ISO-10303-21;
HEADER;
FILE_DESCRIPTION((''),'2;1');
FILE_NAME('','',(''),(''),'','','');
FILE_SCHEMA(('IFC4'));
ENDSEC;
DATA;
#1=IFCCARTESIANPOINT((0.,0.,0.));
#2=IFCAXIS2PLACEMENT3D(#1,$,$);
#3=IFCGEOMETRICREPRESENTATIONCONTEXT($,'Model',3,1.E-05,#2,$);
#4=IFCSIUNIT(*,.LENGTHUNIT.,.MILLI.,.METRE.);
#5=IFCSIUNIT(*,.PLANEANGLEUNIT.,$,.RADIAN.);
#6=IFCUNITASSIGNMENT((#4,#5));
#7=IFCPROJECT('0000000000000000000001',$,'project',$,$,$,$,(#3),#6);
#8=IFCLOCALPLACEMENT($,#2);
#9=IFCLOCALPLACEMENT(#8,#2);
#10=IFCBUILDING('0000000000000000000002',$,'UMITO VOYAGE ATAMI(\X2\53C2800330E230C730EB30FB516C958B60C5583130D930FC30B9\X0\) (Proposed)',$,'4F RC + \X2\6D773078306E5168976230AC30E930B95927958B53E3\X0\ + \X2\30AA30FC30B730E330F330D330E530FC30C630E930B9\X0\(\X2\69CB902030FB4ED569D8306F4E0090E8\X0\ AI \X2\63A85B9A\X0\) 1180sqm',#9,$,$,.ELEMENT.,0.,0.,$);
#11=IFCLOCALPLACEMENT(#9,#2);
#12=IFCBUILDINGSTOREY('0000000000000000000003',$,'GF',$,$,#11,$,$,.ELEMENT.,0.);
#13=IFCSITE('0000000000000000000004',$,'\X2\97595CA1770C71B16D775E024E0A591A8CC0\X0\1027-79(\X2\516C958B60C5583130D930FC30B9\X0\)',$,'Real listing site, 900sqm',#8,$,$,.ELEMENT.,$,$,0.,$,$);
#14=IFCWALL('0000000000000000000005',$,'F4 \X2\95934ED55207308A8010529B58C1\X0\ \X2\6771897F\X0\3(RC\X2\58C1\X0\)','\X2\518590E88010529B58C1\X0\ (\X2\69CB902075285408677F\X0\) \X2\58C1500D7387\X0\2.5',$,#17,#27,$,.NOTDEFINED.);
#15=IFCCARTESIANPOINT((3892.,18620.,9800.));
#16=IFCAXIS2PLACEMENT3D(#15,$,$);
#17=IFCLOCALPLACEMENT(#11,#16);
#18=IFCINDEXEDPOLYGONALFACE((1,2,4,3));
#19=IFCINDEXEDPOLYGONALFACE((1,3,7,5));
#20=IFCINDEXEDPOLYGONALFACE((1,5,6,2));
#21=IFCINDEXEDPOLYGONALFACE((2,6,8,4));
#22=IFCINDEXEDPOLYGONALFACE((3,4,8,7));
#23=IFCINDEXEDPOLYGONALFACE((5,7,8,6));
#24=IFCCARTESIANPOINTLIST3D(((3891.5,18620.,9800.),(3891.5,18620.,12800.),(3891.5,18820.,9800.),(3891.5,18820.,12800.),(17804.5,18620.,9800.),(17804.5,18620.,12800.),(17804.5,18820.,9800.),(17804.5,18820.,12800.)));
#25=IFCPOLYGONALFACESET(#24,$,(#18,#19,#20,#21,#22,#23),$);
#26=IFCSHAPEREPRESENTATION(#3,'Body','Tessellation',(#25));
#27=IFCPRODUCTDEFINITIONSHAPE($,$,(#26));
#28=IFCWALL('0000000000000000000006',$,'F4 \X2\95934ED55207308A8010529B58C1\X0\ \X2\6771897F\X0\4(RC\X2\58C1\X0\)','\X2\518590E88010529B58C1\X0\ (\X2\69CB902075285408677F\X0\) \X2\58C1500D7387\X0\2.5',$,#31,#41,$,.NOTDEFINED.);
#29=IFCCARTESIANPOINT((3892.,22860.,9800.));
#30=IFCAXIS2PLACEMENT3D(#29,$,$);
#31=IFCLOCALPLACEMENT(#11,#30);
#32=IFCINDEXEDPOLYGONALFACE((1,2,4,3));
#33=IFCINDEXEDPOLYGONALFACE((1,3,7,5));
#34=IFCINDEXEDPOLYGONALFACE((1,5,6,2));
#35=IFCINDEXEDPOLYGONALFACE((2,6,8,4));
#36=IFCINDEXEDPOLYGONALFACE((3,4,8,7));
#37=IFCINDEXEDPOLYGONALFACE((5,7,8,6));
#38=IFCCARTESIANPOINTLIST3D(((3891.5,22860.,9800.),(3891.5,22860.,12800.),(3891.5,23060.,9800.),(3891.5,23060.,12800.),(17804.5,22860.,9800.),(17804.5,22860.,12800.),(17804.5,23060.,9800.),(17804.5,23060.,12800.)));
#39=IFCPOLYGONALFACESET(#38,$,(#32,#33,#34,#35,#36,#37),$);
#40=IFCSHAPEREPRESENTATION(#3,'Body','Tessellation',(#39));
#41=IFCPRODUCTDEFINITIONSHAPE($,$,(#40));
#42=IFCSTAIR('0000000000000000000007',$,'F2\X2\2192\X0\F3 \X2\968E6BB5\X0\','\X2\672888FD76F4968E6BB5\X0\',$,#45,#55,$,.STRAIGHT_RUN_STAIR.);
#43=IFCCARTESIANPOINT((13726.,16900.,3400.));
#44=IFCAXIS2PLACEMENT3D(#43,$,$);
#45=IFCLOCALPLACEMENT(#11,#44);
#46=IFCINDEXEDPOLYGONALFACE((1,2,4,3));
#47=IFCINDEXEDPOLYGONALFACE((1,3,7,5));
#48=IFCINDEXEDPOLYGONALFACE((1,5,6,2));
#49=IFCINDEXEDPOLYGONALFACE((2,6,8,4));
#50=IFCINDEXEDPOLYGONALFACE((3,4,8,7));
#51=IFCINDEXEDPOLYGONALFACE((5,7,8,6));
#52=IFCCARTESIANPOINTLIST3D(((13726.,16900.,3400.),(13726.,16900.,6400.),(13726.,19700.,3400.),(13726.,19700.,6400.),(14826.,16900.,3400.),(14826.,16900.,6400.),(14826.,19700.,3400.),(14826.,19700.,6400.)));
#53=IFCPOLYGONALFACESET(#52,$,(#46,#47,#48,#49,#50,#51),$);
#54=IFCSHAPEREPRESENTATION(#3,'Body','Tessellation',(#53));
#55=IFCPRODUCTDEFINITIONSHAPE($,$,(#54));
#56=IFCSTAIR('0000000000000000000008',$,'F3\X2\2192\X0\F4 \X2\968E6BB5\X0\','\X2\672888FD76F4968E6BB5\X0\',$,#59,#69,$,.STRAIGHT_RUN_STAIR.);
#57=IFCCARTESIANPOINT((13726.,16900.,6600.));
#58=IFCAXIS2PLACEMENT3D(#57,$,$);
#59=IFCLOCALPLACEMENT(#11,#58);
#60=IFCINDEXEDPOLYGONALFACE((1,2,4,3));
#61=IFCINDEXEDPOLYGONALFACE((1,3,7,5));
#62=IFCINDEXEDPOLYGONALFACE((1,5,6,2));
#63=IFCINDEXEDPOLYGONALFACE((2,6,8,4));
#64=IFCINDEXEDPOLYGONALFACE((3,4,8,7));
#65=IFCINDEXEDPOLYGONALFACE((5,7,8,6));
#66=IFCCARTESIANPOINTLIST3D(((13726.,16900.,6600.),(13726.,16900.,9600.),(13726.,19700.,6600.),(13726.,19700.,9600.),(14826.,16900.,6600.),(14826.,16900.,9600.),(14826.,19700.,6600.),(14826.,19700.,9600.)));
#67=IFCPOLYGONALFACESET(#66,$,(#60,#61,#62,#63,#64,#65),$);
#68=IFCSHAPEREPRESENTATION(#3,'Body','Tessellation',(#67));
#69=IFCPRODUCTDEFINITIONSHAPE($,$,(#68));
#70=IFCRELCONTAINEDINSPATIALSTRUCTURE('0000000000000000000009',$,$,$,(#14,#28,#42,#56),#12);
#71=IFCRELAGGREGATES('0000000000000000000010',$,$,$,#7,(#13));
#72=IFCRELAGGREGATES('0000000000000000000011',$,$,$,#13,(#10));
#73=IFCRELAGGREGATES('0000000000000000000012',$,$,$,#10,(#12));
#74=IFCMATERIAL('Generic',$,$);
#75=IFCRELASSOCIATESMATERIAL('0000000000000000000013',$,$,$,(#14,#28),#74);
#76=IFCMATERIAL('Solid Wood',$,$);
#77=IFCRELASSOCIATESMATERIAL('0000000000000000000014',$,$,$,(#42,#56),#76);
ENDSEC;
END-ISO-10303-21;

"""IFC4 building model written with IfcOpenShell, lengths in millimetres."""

from ifc_helpers import new_model, si_unit, frame, frame_2d, origin, place, context, project, spatial, rectangle, extrude, material, element, save


model = new_model("IFC4")

# Units and contexts
model_context = context("Model", 3, precision=1e-05, world=origin())
ifc_project = project(units=[si_unit("LENGTHUNIT", "METRE", prefix="MILLI"), si_unit("PLANEANGLEUNIT", "RADIAN")], contexts=[model_context])

# Site, building, storey
site_placement = place(None, origin())
site = spatial("IfcSite", under=ifc_project, at=site_placement, Name="静岡県熱海市上多賀1027-79(公開情報ベース)", ObjectType="Real listing site, 900sqm", CompositionType="ELEMENT", RefElevation=0.0)
building_placement = place(site_placement, origin())
building = spatial("IfcBuilding", under=site, at=building_placement, Name="UMITO VOYAGE ATAMI(参考モデル・公開情報ベース) (Proposed)", ObjectType="4F RC + 海への全面ガラス大開口 + オーシャンビューテラス(構造・仕様は一部 AI 推定) 1180sqm", CompositionType="ELEMENT", ElevationOfRefHeight=0.0, ElevationOfTerrain=0.0)
storey_placement = place(building_placement, origin())
storey = spatial("IfcBuildingStorey", under=building, at=storey_placement, Name="GF", CompositionType="ELEMENT", Elevation=0.0)

# Shared definitions
ifc_material_1 = material(Name="Generic")

# Walls
wall_1_placement = place(storey_placement, frame((3892.0, 18620.0, 9800.0)))
element("IfcWall", 1, at=wall_1_placement, inside=storey, material=ifc_material_1, Name="F4 間仕切り耐力壁 東西3(RC壁)", Description="内部耐力壁 (構造用合板) 壁倍率2.5", PredefinedType="NOTDEFINED", context=model_context, shape_type="SweptSolid", body=[
    extrude(rectangle(XDim=13913.0, YDim=200.0, at=frame_2d((6956.0, 100.0))), frame((3892.0, 18620.0, 9800.0)), (0.0, 0.0, 1.0), 3000.0),
])
wall_2_placement = place(storey_placement, frame((3892.0, 22860.0, 9800.0)))
element("IfcWall", 2, at=wall_2_placement, inside=storey, material=ifc_material_1, Name="F4 間仕切り耐力壁 東西4(RC壁)", Description="内部耐力壁 (構造用合板) 壁倍率2.5", PredefinedType="NOTDEFINED", context=model_context, shape_type="SweptSolid", body=[
    extrude(rectangle(XDim=13913.0, YDim=200.0, at=frame_2d((6956.0, 100.0))), frame((3892.0, 22860.0, 9800.0)), (0.0, 0.0, 1.0), 3000.0),
])

# Stairs
ifc_material_2 = material(Name="Solid Wood")
stair_1_placement = place(storey_placement, frame((13726.0, 16900.0, 3400.0)))
element("IfcStair", 3, at=stair_1_placement, inside=storey, material=ifc_material_2, Name="F2→F3 階段", Description="木製直階段", PredefinedType="STRAIGHT_RUN_STAIR", context=model_context, shape_type="SweptSolid", body=[
    extrude(rectangle(XDim=1100.0, YDim=2800.0, at=frame_2d((550.0, 1400.0))), frame((13726.0, 16900.0, 3400.0)), (0.0, 0.0, 1.0), 3000.0),
])
stair_2_placement = place(storey_placement, frame((13726.0, 16900.0, 6600.0)))
element("IfcStair", 4, at=stair_2_placement, inside=storey, material=ifc_material_2, Name="F3→F4 階段", Description="木製直階段", PredefinedType="STRAIGHT_RUN_STAIR", context=model_context, shape_type="SweptSolid", body=[
    extrude(rectangle(XDim=1100.0, YDim=2800.0, at=frame_2d((550.0, 1400.0))), frame((13726.0, 16900.0, 6600.0)), (0.0, 0.0, 1.0), 3000.0),
])

save(model, "model.ifc")
